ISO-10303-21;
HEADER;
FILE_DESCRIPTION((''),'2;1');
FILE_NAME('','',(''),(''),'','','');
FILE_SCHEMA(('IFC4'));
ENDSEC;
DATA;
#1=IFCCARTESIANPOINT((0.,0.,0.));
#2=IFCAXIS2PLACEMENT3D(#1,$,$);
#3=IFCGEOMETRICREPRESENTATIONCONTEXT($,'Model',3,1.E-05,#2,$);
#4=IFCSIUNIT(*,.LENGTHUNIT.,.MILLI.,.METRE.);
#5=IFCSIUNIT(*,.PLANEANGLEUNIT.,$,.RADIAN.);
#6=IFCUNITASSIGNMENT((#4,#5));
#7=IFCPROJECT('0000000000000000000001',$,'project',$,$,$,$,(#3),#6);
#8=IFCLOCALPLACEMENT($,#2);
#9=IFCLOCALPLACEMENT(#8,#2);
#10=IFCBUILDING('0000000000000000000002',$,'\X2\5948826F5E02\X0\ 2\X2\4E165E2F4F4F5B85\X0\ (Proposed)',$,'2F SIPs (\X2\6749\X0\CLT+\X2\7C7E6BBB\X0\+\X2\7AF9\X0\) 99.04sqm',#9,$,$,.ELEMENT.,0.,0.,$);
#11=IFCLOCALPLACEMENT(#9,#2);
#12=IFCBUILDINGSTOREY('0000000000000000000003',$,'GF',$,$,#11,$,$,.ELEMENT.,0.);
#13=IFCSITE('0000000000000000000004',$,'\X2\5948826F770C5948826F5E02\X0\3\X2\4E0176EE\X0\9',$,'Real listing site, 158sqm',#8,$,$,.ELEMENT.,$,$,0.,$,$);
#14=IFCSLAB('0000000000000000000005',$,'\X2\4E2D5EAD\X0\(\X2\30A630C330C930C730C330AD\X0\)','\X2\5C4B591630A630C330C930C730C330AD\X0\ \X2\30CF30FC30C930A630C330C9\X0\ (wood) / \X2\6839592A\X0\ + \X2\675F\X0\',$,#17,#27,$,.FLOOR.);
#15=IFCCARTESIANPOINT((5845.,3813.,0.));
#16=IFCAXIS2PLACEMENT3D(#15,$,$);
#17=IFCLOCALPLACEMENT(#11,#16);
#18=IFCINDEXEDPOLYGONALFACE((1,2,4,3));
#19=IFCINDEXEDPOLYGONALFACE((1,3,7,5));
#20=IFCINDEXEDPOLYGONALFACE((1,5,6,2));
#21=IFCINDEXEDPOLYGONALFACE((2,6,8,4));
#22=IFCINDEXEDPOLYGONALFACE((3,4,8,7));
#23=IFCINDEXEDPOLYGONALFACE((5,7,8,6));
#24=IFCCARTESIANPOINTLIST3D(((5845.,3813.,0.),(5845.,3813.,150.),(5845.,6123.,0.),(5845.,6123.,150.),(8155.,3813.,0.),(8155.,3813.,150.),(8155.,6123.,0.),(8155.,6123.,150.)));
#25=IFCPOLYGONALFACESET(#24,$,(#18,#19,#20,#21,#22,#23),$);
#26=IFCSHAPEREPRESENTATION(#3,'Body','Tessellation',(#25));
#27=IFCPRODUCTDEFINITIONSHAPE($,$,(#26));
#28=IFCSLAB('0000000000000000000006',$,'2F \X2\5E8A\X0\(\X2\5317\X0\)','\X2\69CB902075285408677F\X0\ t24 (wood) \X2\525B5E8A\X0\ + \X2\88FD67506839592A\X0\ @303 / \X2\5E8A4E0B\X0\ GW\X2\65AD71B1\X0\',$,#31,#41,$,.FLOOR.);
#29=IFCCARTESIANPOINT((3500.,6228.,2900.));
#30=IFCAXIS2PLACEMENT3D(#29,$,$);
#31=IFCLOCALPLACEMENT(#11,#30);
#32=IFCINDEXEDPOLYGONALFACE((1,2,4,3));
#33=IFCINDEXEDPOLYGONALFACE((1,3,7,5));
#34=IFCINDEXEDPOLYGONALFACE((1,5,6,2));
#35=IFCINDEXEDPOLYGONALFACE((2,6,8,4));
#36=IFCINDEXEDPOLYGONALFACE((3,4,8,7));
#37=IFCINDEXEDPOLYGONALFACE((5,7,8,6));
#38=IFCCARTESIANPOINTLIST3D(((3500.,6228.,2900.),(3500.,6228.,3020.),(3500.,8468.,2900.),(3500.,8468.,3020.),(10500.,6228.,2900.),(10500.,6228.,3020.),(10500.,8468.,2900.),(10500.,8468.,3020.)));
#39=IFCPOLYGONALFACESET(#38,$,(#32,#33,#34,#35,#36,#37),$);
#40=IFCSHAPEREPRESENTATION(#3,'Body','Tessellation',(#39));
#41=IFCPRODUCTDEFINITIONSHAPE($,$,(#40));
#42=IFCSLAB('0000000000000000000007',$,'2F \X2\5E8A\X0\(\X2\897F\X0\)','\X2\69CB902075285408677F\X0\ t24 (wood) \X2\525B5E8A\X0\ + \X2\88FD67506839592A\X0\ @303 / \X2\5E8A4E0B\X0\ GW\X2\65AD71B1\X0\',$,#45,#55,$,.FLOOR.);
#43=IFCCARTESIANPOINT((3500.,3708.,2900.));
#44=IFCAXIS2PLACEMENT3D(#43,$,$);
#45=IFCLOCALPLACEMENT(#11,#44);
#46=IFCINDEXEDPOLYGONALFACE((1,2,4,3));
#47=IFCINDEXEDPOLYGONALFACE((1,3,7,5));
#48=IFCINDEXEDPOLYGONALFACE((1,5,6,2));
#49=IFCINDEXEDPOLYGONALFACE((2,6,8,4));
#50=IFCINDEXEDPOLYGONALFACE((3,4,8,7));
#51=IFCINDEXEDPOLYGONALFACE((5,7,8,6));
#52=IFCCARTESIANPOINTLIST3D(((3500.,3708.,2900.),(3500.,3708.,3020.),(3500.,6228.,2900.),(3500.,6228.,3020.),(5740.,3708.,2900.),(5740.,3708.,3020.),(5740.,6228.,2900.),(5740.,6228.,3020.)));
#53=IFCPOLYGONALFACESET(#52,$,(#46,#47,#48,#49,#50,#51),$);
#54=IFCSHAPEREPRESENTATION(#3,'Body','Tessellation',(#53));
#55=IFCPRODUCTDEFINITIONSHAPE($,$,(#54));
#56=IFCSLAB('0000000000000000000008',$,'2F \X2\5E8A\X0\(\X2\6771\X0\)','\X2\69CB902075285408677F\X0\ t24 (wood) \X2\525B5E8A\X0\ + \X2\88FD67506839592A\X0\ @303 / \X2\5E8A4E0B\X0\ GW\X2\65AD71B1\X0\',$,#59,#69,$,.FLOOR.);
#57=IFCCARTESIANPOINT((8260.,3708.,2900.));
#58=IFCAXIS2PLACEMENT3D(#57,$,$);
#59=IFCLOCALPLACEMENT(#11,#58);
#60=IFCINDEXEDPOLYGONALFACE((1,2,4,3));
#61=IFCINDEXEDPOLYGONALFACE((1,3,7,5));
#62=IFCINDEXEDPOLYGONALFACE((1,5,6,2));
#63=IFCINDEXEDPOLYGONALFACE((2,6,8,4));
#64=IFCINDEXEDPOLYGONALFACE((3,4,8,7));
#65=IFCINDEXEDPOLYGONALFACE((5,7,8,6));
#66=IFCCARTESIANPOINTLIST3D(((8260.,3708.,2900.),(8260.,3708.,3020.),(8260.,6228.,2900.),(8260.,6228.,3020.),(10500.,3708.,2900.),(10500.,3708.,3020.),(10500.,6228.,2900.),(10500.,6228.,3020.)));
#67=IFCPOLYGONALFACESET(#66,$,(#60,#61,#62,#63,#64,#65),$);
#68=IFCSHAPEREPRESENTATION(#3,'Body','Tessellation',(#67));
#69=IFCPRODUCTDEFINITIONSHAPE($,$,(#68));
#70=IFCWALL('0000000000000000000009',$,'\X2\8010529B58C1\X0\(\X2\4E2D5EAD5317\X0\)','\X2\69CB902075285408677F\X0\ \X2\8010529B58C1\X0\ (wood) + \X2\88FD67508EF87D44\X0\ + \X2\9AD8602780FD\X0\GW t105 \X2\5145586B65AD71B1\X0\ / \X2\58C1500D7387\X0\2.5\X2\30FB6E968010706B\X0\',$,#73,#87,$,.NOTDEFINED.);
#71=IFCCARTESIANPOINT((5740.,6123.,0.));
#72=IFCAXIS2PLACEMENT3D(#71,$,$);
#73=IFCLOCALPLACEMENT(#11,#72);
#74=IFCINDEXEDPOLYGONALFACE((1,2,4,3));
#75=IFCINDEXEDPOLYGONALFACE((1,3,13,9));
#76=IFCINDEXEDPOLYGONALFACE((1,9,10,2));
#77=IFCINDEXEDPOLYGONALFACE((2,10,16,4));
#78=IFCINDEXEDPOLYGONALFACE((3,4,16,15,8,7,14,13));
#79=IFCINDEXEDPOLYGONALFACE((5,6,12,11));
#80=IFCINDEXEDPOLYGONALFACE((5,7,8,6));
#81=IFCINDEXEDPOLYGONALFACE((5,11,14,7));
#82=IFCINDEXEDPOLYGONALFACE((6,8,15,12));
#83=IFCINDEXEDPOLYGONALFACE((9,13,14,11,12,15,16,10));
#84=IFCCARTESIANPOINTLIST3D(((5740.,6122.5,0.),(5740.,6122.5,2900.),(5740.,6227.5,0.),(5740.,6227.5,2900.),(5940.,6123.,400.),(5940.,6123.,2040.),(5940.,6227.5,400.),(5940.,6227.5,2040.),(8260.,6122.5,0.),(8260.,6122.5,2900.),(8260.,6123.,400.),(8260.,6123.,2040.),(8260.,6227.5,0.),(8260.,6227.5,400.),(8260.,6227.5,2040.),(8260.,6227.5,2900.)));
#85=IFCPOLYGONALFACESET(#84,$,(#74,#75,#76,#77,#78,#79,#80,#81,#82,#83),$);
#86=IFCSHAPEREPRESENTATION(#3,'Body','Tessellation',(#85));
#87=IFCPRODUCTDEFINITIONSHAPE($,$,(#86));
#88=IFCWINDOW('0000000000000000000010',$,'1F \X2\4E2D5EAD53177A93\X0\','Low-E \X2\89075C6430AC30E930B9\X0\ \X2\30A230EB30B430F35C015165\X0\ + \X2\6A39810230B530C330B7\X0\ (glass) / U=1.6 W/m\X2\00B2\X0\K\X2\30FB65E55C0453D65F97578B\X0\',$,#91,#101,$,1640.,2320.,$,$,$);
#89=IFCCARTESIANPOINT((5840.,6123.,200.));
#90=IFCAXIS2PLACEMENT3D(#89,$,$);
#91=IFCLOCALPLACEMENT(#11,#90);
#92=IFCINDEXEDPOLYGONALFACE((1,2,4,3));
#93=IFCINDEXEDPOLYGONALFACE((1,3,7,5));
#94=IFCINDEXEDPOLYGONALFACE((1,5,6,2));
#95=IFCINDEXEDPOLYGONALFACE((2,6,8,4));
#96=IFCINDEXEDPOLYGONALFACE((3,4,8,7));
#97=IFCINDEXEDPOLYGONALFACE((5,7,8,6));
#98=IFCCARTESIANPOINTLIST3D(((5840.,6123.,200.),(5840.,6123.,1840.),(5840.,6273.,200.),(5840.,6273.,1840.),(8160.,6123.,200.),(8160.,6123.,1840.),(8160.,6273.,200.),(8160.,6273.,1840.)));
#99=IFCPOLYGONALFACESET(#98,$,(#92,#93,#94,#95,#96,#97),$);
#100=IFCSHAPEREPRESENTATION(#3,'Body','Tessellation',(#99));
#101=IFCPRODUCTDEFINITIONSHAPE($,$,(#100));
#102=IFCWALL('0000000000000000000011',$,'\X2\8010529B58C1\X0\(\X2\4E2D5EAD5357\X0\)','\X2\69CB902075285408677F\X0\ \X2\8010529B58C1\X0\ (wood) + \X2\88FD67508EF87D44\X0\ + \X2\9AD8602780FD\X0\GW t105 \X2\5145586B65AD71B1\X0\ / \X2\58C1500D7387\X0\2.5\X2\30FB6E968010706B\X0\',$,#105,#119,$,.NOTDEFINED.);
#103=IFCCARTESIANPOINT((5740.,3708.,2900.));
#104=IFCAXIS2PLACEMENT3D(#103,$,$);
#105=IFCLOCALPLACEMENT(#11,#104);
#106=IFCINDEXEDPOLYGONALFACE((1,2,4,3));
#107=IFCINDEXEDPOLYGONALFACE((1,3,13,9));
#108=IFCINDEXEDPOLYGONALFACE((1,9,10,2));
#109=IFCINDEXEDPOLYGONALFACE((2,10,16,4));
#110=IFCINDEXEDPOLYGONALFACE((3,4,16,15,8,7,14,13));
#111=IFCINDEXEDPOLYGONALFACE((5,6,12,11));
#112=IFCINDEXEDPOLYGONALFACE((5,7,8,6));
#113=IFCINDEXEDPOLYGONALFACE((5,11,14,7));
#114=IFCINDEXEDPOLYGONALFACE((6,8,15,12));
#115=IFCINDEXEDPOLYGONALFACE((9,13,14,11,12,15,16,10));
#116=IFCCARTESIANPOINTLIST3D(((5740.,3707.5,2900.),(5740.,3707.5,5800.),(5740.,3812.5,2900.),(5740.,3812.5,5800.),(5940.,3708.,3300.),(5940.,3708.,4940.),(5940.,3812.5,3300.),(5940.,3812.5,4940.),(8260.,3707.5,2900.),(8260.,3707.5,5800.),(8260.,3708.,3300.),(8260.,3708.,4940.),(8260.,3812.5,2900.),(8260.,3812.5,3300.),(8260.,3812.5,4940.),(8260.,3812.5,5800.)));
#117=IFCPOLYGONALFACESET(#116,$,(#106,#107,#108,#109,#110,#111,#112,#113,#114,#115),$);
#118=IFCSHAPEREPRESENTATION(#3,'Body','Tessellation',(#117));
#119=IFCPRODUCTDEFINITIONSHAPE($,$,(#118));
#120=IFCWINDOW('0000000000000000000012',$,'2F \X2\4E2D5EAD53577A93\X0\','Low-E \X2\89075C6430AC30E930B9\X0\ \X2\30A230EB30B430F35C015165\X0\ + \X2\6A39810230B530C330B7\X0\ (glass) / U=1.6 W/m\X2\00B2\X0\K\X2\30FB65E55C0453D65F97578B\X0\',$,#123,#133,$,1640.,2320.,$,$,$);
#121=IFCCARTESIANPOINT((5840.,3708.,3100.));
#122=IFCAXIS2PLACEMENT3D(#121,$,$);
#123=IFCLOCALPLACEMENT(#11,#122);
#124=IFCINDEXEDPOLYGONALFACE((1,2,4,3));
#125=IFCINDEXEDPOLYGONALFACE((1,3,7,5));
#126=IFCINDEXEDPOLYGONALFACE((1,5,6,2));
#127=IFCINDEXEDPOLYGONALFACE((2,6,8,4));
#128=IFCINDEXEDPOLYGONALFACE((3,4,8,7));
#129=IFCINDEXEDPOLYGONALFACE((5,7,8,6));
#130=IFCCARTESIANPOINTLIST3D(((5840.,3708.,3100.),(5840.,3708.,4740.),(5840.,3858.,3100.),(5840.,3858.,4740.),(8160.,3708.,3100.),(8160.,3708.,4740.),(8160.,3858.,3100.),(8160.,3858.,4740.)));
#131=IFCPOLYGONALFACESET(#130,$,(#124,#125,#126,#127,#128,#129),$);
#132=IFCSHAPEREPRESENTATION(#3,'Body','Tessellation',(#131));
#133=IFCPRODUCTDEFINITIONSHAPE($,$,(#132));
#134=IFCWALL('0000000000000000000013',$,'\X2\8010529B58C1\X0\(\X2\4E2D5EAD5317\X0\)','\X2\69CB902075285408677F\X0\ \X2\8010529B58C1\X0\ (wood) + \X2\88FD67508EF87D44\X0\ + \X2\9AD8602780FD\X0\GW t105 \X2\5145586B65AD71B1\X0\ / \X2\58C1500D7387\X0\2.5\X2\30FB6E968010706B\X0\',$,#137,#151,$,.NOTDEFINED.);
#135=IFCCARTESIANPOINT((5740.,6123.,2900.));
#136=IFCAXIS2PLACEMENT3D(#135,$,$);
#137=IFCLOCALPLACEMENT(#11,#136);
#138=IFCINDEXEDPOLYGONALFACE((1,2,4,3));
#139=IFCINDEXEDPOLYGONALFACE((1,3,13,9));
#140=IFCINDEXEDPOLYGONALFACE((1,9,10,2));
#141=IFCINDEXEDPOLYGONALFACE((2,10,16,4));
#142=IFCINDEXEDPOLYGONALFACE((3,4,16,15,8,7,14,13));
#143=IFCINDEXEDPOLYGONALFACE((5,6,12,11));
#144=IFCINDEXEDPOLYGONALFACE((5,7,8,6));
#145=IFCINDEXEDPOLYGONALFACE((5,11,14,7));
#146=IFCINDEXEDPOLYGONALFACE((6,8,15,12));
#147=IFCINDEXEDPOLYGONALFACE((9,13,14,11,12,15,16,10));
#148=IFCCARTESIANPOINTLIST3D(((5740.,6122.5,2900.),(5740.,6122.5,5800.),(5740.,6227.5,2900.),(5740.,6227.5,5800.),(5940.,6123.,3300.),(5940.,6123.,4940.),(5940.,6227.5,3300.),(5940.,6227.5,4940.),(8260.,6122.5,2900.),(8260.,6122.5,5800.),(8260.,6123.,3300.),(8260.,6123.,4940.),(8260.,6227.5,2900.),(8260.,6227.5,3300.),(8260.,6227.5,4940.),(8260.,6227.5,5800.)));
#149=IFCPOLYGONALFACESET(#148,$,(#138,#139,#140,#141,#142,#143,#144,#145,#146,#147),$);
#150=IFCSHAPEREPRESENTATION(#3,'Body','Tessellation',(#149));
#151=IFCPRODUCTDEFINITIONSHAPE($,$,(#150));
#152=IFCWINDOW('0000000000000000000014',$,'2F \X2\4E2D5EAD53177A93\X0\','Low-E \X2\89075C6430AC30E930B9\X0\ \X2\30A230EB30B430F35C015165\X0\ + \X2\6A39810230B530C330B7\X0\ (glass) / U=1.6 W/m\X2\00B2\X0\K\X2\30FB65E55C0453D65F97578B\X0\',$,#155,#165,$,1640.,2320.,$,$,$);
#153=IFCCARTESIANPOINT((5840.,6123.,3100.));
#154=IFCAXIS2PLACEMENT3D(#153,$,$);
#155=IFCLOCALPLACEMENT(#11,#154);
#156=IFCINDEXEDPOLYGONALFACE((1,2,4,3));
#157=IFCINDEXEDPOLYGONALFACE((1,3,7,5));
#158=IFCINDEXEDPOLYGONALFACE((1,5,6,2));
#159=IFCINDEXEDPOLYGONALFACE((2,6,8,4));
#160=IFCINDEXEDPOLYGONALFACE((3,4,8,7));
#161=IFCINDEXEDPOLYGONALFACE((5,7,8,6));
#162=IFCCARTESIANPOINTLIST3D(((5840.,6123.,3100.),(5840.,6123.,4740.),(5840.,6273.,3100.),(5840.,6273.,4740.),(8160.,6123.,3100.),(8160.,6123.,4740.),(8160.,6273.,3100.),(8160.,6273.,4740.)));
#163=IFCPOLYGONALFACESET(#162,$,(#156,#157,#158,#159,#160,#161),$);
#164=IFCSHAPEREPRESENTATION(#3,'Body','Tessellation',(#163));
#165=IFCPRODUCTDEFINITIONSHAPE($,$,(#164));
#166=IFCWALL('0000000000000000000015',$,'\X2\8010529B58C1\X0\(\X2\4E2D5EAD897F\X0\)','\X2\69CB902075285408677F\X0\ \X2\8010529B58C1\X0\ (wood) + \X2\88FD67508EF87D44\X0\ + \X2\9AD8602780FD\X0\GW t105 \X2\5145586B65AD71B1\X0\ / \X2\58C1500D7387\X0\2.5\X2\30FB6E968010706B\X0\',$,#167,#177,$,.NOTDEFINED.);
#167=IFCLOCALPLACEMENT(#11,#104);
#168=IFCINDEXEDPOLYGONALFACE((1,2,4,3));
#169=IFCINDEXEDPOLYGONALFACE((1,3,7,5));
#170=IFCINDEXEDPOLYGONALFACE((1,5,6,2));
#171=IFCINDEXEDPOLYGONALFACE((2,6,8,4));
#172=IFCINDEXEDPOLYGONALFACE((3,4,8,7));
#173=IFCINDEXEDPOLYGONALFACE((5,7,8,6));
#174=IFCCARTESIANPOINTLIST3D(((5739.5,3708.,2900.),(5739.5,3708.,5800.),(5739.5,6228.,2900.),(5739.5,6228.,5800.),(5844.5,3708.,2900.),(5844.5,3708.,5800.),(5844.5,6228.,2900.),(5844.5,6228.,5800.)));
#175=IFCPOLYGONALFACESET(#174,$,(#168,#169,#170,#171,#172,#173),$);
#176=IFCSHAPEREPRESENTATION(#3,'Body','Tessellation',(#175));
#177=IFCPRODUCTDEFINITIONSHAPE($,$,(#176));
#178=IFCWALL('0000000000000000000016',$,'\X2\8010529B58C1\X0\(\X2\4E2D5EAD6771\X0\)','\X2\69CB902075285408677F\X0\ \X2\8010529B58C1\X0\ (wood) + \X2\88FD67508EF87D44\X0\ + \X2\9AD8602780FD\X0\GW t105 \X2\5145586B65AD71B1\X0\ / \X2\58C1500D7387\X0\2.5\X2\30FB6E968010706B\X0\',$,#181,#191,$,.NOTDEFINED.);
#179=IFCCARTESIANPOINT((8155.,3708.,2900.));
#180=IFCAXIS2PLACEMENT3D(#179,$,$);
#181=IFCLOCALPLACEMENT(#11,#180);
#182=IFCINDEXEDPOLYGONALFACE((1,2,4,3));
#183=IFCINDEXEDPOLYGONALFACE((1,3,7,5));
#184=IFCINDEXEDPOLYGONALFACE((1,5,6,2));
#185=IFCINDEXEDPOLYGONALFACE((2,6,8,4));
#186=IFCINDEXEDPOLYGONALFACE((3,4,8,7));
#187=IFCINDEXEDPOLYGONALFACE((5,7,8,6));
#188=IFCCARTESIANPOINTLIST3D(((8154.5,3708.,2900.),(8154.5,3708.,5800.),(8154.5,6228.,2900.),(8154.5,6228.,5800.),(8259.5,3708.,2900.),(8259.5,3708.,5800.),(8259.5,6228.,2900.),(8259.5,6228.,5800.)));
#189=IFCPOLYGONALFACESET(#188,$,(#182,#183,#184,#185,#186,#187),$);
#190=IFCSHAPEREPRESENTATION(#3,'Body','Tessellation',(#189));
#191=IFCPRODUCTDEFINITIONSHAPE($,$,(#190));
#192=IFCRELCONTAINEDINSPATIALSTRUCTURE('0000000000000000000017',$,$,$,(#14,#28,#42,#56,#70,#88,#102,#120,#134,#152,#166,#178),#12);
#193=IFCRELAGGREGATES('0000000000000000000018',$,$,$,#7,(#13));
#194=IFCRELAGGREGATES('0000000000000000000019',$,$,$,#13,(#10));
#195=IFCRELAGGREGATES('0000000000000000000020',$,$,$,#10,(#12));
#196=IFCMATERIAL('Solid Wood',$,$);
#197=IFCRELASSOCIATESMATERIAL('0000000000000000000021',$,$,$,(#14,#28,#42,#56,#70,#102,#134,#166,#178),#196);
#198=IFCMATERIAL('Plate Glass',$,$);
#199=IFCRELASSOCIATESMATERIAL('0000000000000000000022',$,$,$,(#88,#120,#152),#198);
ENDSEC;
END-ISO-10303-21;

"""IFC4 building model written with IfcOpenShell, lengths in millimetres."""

from ifc_helpers import new_model, si_unit, frame, frame_2d, origin, place, context, project, spatial, rectangle, extrude, material, element, fill, save


model = new_model("IFC4")

# Units and contexts
model_context = context("Model", 3, precision=1e-05, world=origin())
ifc_project = project(units=[si_unit("LENGTHUNIT", "METRE", prefix="MILLI"), si_unit("PLANEANGLEUNIT", "RADIAN")], contexts=[model_context])

# Site, building, storey
site_placement = place(None, origin())
site = spatial("IfcSite", under=ifc_project, at=site_placement, Name="奈良県奈良市3丁目9", ObjectType="Real listing site, 158sqm", CompositionType="ELEMENT", RefElevation=0.0)
building_placement = place(site_placement, origin())
building = spatial("IfcBuilding", under=site, at=building_placement, Name="奈良市 2世帯住宅 (Proposed)", ObjectType="2F SIPs (杉CLT+籾殻+竹) 99.04sqm", CompositionType="ELEMENT", ElevationOfRefHeight=0.0, ElevationOfTerrain=0.0)
storey_placement = place(building_placement, origin())
storey = spatial("IfcBuildingStorey", under=building, at=storey_placement, Name="GF", CompositionType="ELEMENT", Elevation=0.0)

# Slabs
ifc_material_1 = material(Name="Solid Wood")
slab_1_placement = place(storey_placement, frame((5845.0, 3813.0, 0.0)))
element("IfcSlab", 1, at=slab_1_placement, inside=storey, material=ifc_material_1, Name="中庭(ウッドデッキ)", Description="屋外ウッドデッキ ハードウッド (wood) / 根太 + 束", PredefinedType="FLOOR", context=model_context, shape_type="SweptSolid", body=[
    extrude(rectangle(XDim=2310.0, YDim=2310.0, at=frame_2d((1155.0, 1155.0))), frame((5845.0, 3813.0, 0.0)), (0.0, 0.0, 1.0), 150.0),
])
slab_2_placement = place(storey_placement, frame((3500.0, 6228.0, 2900.0)))
element("IfcSlab", 2, at=slab_2_placement, inside=storey, material=ifc_material_1, Name="2F 床(北)", Description="構造用合板 t24 (wood) 剛床 + 製材根太 @303 / 床下 GW断熱", PredefinedType="FLOOR", context=model_context, shape_type="SweptSolid", body=[
    extrude(rectangle(XDim=7000.0, YDim=2240.0, at=frame_2d((3500.0, 1120.0))), frame((3500.0, 6228.0, 2900.0)), (0.0, 0.0, 1.0), 120.0),
])
slab_3_placement = place(storey_placement, frame((3500.0, 3708.0, 2900.0)))
element("IfcSlab", 3, at=slab_3_placement, inside=storey, material=ifc_material_1, Name="2F 床(西)", Description="構造用合板 t24 (wood) 剛床 + 製材根太 @303 / 床下 GW断熱", PredefinedType="FLOOR", context=model_context, shape_type="SweptSolid", body=[
    extrude(rectangle(XDim=2240.0, YDim=2520.0, at=frame_2d((1120.0, 1260.0))), frame((3500.0, 3708.0, 2900.0)), (0.0, 0.0, 1.0), 120.0),
])
slab_4_placement = place(storey_placement, frame((8260.0, 3708.0, 2900.0)))
element("IfcSlab", 4, at=slab_4_placement, inside=storey, material=ifc_material_1, Name="2F 床(東)", Description="構造用合板 t24 (wood) 剛床 + 製材根太 @303 / 床下 GW断熱", PredefinedType="FLOOR", context=model_context, shape_type="SweptSolid", body=[
    extrude(rectangle(XDim=2240.0, YDim=2520.0, at=frame_2d((1120.0, 1260.0))), frame((8260.0, 3708.0, 2900.0)), (0.0, 0.0, 1.0), 120.0),
])

# Wall, opening, window
wall_1_placement = place(storey_placement, frame((5740.0, 6123.0, 0.0)))
wall_1 = element("IfcWall", 5, at=wall_1_placement, inside=storey, material=ifc_material_1, Name="耐力壁(中庭北)", Description="構造用合板 耐力壁 (wood) + 製材軸組 + 高性能GW t105 充填断熱 / 壁倍率2.5・準耐火", PredefinedType="NOTDEFINED", context=model_context, shape_type="SweptSolid", body=[
    extrude(rectangle(XDim=2520.0, YDim=105.0, at=frame_2d((1260.0, 52.0))), frame((5740.0, 6123.0, 0.0)), (0.0, 0.0, 1.0), 2900.0),
])
opening_1_placement = place(storey_placement, frame((5840.0, 6123.0, 200.0)))
opening_1 = element("IfcOpeningElement", 6, at=opening_1_placement, cuts=wall_1, PredefinedType="NOTDEFINED", context=model_context, shape_type="SweptSolid", body=[
    extrude(rectangle(XDim=2320.0, YDim=150.0, at=frame_2d((1160.0, 75.0))), frame((5840.0, 6123.0, 200.0)), (0.0, 0.0, 1.0), 1640.0),
])
ifc_material_2 = material(Name="Plate Glass")
window_1_placement = place(storey_placement, frame((5840.0, 6123.0, 200.0)))
window_1 = element("IfcWindow", 7, at=window_1_placement, inside=storey, material=ifc_material_2, Name="1F 中庭北窓", Description="Low-E 複層ガラス アルゴン封入 + 樹脂サッシ (glass) / U=1.6 W/m²K・日射取得型", OverallHeight=1640.0, OverallWidth=2320.0, context=model_context, shape_type="SweptSolid", body=[
    extrude(rectangle(XDim=2320.0, YDim=150.0, at=frame_2d((1160.0, 75.0))), frame((5840.0, 6123.0, 200.0)), (0.0, 0.0, 1.0), 1640.0),
])
fill(opening_1, window_1)

# Walls, openings, windows
wall_2_placement = place(storey_placement, frame((5740.0, 3708.0, 2900.0)))
wall_2 = element("IfcWall", 8, at=wall_2_placement, inside=storey, material=ifc_material_1, Name="耐力壁(中庭南)", Description="構造用合板 耐力壁 (wood) + 製材軸組 + 高性能GW t105 充填断熱 / 壁倍率2.5・準耐火", PredefinedType="NOTDEFINED", context=model_context, shape_type="SweptSolid", body=[
    extrude(rectangle(XDim=2520.0, YDim=105.0, at=frame_2d((1260.0, 52.0))), frame((5740.0, 3708.0, 2900.0)), (0.0, 0.0, 1.0), 2900.0),
])
opening_2_placement = place(storey_placement, frame((5840.0, 3708.0, 3100.0)))
opening_2 = element("IfcOpeningElement", 9, at=opening_2_placement, cuts=wall_2, PredefinedType="NOTDEFINED", context=model_context, shape_type="SweptSolid", body=[
    extrude(rectangle(XDim=2320.0, YDim=150.0, at=frame_2d((1160.0, 75.0))), frame((5840.0, 3708.0, 3100.0)), (0.0, 0.0, 1.0), 1640.0),
])
window_2_placement = place(storey_placement, frame((5840.0, 3708.0, 3100.0)))
window_2 = element("IfcWindow", 10, at=window_2_placement, inside=storey, material=ifc_material_2, Name="2F 中庭南窓", Description="Low-E 複層ガラス アルゴン封入 + 樹脂サッシ (glass) / U=1.6 W/m²K・日射取得型", OverallHeight=1640.0, OverallWidth=2320.0, context=model_context, shape_type="SweptSolid", body=[
    extrude(rectangle(XDim=2320.0, YDim=150.0, at=frame_2d((1160.0, 75.0))), frame((5840.0, 3708.0, 3100.0)), (0.0, 0.0, 1.0), 1640.0),
])
fill(opening_2, window_2)
wall_3_placement = place(storey_placement, frame((5740.0, 6123.0, 2900.0)))
wall_3 = element("IfcWall", 11, at=wall_3_placement, inside=storey, material=ifc_material_1, Name="耐力壁(中庭北)", Description="構造用合板 耐力壁 (wood) + 製材軸組 + 高性能GW t105 充填断熱 / 壁倍率2.5・準耐火", PredefinedType="NOTDEFINED", context=model_context, shape_type="SweptSolid", body=[
    extrude(rectangle(XDim=2520.0, YDim=105.0, at=frame_2d((1260.0, 52.0))), frame((5740.0, 6123.0, 2900.0)), (0.0, 0.0, 1.0), 2900.0),
])
opening_3_placement = place(storey_placement, frame((5840.0, 6123.0, 3100.0)))
opening_3 = element("IfcOpeningElement", 12, at=opening_3_placement, cuts=wall_3, PredefinedType="NOTDEFINED", context=model_context, shape_type="SweptSolid", body=[
    extrude(rectangle(XDim=2320.0, YDim=150.0, at=frame_2d((1160.0, 75.0))), frame((5840.0, 6123.0, 3100.0)), (0.0, 0.0, 1.0), 1640.0),
])
window_3_placement = place(storey_placement, frame((5840.0, 6123.0, 3100.0)))
window_3 = element("IfcWindow", 13, at=window_3_placement, inside=storey, material=ifc_material_2, Name="2F 中庭北窓", Description="Low-E 複層ガラス アルゴン封入 + 樹脂サッシ (glass) / U=1.6 W/m²K・日射取得型", OverallHeight=1640.0, OverallWidth=2320.0, context=model_context, shape_type="SweptSolid", body=[
    extrude(rectangle(XDim=2320.0, YDim=150.0, at=frame_2d((1160.0, 75.0))), frame((5840.0, 6123.0, 3100.0)), (0.0, 0.0, 1.0), 1640.0),
])
fill(opening_3, window_3)

# Walls
wall_4_placement = place(storey_placement, frame((5740.0, 3708.0, 2900.0)))
element("IfcWall", 14, at=wall_4_placement, inside=storey, material=ifc_material_1, Name="耐力壁(中庭西)", Description="構造用合板 耐力壁 (wood) + 製材軸組 + 高性能GW t105 充填断熱 / 壁倍率2.5・準耐火", PredefinedType="NOTDEFINED", context=model_context, shape_type="SweptSolid", body=[
    extrude(rectangle(XDim=105.0, YDim=2520.0, at=frame_2d((52.0, 1260.0))), frame((5740.0, 3708.0, 2900.0)), (0.0, 0.0, 1.0), 2900.0),
])
wall_5_placement = place(storey_placement, frame((8155.0, 3708.0, 2900.0)))
element("IfcWall", 15, at=wall_5_placement, inside=storey, material=ifc_material_1, Name="耐力壁(中庭東)", Description="構造用合板 耐力壁 (wood) + 製材軸組 + 高性能GW t105 充填断熱 / 壁倍率2.5・準耐火", PredefinedType="NOTDEFINED", context=model_context, shape_type="SweptSolid", body=[
    extrude(rectangle(XDim=105.0, YDim=2520.0, at=frame_2d((52.0, 1260.0))), frame((8155.0, 3708.0, 2900.0)), (0.0, 0.0, 1.0), 2900.0),
])

save(model, "model.ifc")
